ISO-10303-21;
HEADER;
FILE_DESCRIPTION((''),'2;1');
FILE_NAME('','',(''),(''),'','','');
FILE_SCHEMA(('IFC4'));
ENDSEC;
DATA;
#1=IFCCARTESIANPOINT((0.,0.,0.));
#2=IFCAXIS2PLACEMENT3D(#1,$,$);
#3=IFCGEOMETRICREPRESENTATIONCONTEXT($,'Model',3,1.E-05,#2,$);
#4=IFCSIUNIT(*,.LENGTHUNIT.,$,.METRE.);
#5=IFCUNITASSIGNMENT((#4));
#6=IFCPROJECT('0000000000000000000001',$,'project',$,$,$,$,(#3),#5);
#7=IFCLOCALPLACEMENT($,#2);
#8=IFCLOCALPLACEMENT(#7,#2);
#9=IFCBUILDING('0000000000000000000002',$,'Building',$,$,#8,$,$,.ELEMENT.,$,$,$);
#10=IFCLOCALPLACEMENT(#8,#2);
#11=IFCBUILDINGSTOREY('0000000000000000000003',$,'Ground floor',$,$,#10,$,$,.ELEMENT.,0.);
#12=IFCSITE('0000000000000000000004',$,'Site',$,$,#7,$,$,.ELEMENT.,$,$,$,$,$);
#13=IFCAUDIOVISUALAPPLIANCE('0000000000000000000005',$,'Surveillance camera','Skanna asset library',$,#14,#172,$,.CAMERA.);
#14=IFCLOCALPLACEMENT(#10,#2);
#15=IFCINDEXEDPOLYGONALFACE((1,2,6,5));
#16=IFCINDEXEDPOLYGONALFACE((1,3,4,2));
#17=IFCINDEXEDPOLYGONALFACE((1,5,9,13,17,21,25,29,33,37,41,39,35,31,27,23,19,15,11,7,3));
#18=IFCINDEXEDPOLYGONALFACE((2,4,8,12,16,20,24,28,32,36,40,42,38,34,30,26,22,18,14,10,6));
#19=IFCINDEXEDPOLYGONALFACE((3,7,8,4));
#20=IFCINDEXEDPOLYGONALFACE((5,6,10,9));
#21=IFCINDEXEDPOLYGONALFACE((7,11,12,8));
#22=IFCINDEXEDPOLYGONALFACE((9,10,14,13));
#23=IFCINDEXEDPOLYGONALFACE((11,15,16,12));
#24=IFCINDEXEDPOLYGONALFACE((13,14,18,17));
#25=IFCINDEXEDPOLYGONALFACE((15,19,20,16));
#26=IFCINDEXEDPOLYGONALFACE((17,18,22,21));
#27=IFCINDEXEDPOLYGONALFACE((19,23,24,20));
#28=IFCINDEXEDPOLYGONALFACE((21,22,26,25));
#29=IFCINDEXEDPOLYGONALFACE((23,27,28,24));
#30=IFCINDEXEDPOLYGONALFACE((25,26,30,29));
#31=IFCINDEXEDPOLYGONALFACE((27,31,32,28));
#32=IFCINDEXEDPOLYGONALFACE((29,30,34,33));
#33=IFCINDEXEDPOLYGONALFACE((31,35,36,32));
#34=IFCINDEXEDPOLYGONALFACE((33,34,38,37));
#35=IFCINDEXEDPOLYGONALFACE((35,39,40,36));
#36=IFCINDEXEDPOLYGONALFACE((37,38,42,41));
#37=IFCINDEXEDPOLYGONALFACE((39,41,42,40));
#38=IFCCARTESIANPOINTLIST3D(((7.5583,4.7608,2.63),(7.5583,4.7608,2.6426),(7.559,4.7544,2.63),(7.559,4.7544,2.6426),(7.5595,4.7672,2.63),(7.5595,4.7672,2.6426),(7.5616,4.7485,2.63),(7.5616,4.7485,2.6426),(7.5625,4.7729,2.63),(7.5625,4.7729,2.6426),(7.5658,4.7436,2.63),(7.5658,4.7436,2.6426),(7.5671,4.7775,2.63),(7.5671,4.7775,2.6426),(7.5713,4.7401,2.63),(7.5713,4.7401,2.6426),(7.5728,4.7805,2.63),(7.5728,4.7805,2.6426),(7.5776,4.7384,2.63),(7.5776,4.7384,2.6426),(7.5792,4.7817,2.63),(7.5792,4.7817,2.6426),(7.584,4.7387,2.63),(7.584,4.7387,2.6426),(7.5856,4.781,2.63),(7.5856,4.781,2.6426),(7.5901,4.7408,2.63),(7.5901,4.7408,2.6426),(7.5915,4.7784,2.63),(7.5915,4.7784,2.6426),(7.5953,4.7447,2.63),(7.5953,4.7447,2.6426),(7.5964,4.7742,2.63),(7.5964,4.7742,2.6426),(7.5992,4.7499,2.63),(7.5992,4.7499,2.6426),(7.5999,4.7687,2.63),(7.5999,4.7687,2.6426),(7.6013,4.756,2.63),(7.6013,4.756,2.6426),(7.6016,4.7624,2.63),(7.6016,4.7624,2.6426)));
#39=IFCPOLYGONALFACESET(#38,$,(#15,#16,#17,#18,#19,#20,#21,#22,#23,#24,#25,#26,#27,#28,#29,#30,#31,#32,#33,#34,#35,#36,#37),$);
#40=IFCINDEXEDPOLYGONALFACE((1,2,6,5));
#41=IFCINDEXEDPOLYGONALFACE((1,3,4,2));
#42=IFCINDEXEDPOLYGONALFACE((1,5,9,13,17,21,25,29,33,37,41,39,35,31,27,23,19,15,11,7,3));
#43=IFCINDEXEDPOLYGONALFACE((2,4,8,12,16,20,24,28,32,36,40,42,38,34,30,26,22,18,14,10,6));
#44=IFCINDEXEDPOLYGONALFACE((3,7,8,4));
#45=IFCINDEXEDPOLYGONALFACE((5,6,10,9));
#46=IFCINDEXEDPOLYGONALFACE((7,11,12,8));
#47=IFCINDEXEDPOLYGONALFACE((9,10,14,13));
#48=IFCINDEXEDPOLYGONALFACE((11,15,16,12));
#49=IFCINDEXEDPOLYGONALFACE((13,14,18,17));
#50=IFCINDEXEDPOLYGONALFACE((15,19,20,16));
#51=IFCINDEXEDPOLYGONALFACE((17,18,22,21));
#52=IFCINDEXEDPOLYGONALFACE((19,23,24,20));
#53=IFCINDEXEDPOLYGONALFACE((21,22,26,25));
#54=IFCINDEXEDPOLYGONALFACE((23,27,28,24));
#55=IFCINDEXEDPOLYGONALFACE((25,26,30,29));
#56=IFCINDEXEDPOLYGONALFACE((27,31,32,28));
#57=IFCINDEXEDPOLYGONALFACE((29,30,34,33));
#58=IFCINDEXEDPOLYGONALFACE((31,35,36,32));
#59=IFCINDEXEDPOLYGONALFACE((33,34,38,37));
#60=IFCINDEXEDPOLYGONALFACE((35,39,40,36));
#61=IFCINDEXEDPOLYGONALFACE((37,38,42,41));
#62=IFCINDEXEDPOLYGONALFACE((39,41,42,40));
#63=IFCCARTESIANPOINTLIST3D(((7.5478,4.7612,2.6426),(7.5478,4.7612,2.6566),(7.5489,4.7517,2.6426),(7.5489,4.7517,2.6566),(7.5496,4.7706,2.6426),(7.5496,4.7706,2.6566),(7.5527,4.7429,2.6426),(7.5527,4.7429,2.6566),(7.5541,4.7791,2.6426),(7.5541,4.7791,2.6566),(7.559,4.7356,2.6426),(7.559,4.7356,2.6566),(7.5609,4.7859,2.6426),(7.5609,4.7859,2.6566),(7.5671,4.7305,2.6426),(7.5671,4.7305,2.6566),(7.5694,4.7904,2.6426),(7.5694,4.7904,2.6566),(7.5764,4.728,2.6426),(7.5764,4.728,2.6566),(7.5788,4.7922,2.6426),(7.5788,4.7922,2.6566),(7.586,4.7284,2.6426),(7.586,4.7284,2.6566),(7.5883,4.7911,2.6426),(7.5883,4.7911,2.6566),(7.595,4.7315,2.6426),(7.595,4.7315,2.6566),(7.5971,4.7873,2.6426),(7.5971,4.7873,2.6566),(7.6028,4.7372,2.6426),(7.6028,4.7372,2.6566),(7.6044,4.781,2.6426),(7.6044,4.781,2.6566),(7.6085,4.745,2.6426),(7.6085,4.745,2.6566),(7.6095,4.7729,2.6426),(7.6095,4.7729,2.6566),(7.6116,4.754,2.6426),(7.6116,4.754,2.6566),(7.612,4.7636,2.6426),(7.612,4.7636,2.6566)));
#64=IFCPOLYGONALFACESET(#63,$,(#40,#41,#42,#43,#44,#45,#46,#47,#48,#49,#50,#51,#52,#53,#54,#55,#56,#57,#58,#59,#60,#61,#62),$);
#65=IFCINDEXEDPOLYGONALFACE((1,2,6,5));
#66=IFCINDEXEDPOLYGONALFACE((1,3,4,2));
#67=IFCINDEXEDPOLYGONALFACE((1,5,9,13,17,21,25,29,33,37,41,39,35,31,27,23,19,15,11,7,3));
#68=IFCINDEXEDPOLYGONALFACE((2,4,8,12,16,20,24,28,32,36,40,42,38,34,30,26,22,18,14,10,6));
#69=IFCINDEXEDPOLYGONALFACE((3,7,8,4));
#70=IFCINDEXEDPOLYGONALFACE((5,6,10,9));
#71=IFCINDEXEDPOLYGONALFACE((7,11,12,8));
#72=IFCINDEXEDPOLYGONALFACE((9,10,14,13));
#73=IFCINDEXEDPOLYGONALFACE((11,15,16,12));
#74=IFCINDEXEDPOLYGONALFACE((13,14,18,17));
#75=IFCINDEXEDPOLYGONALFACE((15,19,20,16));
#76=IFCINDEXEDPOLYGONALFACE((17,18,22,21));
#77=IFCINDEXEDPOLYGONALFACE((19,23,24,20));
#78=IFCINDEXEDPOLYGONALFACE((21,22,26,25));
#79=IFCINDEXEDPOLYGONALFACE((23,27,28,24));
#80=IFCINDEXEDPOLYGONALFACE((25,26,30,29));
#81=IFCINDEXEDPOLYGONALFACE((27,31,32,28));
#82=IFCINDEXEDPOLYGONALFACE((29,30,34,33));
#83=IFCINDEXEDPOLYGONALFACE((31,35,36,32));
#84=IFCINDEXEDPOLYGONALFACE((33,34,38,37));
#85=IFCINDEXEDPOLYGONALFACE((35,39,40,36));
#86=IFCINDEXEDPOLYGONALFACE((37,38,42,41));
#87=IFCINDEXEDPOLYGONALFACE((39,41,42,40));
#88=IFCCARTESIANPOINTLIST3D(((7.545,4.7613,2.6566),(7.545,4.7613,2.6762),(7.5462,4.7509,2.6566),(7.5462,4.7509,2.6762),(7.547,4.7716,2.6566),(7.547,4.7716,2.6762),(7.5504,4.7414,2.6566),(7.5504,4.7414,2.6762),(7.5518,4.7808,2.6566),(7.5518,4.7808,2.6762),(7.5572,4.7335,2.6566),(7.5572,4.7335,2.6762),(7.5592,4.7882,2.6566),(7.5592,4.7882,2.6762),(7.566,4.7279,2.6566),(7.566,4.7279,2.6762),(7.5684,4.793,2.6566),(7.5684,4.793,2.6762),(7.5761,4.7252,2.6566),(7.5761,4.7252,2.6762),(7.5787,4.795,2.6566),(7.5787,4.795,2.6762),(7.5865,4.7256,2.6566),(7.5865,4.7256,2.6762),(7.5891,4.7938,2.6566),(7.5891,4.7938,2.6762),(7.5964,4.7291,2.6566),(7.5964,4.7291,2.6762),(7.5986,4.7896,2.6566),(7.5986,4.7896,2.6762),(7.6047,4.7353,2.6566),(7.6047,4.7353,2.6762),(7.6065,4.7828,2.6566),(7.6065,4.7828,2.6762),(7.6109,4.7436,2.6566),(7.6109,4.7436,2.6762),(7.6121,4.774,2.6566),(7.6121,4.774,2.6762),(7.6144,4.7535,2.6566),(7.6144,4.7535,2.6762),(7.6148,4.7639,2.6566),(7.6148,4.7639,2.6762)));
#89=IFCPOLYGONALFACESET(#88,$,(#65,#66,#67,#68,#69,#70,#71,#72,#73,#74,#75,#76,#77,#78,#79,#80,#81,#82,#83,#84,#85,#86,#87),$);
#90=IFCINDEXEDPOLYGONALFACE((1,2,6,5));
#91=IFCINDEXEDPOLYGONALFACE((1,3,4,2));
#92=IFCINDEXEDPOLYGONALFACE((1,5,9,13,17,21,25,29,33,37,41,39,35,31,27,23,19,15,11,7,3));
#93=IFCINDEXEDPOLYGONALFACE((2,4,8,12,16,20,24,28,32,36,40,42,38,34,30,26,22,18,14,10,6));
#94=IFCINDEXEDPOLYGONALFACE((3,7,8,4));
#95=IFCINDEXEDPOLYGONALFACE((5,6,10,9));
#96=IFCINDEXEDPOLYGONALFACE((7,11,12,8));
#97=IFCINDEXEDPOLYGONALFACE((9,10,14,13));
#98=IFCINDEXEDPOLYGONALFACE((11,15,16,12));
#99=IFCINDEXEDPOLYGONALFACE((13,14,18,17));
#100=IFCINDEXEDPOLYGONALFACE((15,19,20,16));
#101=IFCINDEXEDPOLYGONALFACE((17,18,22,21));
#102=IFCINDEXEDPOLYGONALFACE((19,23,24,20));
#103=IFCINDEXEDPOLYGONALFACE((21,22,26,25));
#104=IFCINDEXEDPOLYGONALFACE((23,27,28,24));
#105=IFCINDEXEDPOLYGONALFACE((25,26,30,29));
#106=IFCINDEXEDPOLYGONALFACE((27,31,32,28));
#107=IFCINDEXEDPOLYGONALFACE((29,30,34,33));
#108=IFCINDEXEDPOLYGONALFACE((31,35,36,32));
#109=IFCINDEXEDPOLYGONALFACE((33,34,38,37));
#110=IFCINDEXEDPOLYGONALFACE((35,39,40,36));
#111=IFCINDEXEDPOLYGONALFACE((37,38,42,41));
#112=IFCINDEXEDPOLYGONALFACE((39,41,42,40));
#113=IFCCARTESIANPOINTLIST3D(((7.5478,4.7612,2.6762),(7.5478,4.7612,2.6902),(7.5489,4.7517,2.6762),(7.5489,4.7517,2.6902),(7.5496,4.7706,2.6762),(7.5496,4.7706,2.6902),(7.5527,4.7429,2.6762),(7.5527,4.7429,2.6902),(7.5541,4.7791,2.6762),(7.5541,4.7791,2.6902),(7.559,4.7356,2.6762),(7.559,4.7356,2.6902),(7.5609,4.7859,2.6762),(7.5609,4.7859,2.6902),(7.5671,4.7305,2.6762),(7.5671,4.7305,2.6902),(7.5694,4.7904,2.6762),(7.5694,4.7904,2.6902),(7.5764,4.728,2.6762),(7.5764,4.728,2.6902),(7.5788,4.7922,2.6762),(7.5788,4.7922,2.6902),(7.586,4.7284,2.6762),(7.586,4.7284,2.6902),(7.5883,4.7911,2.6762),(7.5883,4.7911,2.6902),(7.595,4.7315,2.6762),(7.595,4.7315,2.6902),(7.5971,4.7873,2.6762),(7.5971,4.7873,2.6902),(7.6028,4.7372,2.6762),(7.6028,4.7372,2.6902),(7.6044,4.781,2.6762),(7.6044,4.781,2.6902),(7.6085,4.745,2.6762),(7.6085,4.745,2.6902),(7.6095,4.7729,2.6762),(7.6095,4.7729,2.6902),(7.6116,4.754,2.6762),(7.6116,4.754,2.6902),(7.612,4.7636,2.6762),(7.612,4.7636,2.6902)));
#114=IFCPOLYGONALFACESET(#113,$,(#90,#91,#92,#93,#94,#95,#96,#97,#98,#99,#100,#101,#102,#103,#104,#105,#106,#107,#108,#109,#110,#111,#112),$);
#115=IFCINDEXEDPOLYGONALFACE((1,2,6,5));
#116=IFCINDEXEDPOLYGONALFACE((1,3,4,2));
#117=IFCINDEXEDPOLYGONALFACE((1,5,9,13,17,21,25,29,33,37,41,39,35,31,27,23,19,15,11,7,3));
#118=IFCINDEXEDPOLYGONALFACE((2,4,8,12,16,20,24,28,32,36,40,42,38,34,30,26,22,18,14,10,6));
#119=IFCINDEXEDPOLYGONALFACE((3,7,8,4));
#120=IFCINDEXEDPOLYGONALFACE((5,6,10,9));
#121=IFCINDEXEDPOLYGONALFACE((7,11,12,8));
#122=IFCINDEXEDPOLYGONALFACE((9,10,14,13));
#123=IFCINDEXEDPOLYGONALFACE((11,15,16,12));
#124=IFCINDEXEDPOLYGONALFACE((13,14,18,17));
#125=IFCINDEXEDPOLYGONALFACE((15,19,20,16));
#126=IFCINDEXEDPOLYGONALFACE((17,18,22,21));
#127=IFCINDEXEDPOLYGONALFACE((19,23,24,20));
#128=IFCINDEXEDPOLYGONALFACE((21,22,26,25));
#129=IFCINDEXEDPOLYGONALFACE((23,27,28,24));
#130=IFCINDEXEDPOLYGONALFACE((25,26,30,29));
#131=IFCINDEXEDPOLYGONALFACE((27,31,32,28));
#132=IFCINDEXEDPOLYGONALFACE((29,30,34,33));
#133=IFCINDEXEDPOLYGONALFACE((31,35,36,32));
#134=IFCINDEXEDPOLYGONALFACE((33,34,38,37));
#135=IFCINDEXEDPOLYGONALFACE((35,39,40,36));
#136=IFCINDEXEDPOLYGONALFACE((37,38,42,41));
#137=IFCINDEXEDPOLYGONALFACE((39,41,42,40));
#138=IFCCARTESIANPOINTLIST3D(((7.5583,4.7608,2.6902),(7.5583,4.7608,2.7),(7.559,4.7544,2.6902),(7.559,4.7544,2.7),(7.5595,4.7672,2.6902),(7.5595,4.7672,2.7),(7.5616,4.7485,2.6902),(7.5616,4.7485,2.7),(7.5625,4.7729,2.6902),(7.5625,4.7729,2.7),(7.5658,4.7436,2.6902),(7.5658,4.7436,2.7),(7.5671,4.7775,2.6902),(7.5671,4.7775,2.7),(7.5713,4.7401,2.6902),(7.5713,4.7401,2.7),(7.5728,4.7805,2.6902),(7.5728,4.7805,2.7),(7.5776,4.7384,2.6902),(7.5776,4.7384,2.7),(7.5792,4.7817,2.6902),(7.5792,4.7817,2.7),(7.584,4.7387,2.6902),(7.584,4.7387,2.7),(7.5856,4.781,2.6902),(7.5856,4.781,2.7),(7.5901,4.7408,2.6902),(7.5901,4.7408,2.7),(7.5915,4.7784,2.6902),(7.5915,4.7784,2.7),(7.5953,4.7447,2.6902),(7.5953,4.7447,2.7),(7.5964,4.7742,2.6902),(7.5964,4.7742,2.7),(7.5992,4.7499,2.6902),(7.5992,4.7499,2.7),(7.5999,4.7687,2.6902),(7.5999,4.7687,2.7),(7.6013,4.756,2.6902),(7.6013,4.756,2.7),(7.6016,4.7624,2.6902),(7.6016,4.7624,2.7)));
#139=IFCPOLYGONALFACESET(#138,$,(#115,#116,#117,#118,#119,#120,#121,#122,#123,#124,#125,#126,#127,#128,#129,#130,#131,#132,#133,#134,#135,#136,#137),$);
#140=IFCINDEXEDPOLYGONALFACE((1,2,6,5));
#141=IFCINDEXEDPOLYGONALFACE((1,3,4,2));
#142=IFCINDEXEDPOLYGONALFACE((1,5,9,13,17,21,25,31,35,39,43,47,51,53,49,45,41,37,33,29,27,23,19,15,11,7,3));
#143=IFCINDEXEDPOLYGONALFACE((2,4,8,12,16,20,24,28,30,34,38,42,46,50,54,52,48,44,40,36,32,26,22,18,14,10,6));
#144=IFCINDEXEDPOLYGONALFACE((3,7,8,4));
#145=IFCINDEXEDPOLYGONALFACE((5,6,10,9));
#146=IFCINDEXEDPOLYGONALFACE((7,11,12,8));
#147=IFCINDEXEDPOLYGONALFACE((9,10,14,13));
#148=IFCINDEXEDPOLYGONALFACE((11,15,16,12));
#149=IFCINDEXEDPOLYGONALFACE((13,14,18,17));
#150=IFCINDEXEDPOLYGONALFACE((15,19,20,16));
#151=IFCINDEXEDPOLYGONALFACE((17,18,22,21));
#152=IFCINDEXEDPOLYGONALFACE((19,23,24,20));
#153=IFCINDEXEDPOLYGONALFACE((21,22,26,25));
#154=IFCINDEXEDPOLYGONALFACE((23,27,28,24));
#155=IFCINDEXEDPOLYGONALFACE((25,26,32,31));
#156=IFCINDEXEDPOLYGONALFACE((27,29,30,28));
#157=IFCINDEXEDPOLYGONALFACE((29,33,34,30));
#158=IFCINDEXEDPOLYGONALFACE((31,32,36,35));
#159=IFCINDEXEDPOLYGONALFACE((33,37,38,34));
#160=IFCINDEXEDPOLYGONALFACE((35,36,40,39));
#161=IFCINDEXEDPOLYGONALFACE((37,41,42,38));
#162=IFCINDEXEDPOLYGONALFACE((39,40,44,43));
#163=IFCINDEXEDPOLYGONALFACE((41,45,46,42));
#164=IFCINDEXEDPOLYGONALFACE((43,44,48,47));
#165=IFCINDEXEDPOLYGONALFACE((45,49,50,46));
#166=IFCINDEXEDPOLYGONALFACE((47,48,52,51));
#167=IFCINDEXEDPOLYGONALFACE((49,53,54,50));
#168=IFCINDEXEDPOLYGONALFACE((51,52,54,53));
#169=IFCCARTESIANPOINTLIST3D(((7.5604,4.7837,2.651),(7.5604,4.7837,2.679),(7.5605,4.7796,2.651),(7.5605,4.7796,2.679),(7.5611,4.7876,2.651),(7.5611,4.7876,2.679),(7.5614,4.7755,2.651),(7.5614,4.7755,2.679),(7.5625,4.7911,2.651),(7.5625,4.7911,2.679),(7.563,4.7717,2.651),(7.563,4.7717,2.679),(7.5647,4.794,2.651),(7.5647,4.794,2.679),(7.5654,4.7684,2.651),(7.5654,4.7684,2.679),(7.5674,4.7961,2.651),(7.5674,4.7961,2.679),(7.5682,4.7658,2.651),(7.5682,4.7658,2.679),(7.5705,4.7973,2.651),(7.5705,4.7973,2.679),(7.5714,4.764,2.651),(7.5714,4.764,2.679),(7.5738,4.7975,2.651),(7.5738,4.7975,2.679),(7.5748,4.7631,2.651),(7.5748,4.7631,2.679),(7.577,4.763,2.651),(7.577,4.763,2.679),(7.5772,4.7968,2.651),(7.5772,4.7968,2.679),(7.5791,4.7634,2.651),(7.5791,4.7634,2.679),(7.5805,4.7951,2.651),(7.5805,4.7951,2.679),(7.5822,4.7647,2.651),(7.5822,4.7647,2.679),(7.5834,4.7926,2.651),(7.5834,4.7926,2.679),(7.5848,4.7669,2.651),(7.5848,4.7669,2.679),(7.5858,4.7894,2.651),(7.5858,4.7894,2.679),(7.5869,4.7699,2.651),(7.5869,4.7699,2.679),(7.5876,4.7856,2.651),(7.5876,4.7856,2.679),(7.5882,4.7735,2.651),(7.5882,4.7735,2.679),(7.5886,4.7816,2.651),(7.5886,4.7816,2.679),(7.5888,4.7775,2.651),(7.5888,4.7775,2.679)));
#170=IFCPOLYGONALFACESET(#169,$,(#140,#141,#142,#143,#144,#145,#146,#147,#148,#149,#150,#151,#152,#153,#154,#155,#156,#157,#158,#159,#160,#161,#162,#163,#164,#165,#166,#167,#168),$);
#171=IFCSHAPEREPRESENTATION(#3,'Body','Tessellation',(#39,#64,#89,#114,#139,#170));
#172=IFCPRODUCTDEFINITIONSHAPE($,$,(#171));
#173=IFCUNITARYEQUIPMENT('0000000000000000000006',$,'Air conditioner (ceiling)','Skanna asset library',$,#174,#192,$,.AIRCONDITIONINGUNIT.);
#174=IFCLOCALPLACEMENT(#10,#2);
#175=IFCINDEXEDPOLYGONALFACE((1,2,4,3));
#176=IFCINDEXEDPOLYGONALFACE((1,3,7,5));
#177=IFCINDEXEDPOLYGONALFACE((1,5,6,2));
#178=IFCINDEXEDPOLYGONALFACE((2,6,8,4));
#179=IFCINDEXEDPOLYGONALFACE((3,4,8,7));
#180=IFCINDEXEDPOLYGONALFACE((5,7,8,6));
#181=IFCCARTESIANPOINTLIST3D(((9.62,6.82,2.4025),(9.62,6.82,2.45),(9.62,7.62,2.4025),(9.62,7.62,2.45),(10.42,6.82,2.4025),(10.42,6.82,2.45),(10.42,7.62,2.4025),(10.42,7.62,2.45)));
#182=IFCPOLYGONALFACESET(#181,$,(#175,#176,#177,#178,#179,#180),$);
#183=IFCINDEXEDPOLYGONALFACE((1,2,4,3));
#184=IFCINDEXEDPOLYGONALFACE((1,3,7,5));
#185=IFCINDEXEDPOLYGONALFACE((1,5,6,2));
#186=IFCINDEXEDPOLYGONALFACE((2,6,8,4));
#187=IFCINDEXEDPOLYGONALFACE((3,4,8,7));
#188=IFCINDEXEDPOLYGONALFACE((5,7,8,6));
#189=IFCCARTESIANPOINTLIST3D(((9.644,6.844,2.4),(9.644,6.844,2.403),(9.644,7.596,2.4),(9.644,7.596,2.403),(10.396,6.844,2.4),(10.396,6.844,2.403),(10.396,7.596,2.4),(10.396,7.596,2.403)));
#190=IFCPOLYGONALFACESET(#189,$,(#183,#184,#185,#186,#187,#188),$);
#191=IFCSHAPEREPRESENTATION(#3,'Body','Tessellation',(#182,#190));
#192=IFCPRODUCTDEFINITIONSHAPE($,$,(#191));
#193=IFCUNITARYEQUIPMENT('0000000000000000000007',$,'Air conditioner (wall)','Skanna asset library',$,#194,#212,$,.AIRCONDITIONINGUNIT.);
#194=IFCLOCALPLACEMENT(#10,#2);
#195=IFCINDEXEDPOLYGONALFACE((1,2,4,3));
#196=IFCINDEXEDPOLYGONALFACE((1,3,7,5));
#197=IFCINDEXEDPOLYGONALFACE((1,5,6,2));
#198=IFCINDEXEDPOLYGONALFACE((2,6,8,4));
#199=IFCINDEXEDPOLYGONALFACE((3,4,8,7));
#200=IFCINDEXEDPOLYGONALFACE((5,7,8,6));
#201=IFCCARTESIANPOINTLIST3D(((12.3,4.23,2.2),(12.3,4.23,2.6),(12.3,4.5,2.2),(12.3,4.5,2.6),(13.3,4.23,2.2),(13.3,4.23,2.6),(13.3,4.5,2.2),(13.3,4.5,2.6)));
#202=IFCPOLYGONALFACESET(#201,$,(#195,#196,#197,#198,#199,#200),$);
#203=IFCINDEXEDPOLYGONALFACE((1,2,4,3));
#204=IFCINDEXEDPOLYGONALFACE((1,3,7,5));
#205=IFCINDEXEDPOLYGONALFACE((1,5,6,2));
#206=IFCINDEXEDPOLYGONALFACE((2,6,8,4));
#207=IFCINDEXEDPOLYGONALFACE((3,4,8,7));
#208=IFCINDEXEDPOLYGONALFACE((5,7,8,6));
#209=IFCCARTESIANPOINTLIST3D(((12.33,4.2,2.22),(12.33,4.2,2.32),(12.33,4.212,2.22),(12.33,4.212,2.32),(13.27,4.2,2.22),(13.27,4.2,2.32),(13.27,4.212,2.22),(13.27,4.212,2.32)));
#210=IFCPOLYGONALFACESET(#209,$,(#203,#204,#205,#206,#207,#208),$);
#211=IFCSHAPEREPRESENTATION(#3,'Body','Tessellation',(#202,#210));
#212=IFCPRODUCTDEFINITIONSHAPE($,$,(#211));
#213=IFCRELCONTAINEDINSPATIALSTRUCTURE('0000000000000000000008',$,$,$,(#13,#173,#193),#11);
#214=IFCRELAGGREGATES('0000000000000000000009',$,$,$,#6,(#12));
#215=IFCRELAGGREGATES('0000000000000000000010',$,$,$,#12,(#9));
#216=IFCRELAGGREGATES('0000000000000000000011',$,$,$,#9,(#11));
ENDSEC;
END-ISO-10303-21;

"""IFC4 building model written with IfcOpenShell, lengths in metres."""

from ifc_helpers import new_model, si_unit, frame, frame_2d, origin, origin_2d, place, context, project, spatial, rectangle, circle, ellipse, extrude, element, save


model = new_model("IFC4")

# Units and contexts
model_context = context("Model", 3, precision=1e-05, world=origin())
ifc_project = project(units=[si_unit("LENGTHUNIT", "METRE")], contexts=[model_context])

# Site, building, storey
site_placement = place(None, origin())
site = spatial("IfcSite", under=ifc_project, at=site_placement, Name="Site", CompositionType="ELEMENT")
building_placement = place(site_placement, origin())
building = spatial("IfcBuilding", under=site, at=building_placement, Name="Building", CompositionType="ELEMENT")
storey_placement = place(building_placement, origin())
storey = spatial("IfcBuildingStorey", under=building, at=storey_placement, Name="Ground floor", CompositionType="ELEMENT", Elevation=0.0)

# Audio visual appliance
audio_visual_appliance_placement = place(storey_placement, frame((7.58, 4.76, 2.63), z_axis=(0.0, 0.0, 1.0), x_axis=(-0.965926, -0.258819, 0.0)))
element("IfcAudioVisualAppliance", 1, at=audio_visual_appliance_placement, inside=storey, Name="Surveillance camera", Description="Skanna asset library", PredefinedType="CAMERA", context=model_context, shape_type="SweptSolid", body=[
    extrude(circle(Radius=0.0217, at=origin_2d()), origin(), (0.0, 0.0, 1.0), 0.0126),
    extrude(circle(Radius=0.0322, at=origin_2d()), frame((0.0, 0.0, 0.0126)), (0.0, 0.0, 1.0), 0.014),
    extrude(circle(Radius=0.035, at=origin_2d()), frame((0.0, 0.0, 0.0266)), (0.0, 0.0, 1.0), 0.0196),
    extrude(circle(Radius=0.0322, at=origin_2d()), frame((0.0, 0.0, 0.0462)), (0.0, 0.0, 1.0), 0.014),
    extrude(circle(Radius=0.0217, at=origin_2d()), frame((0.0, 0.0, 0.0602)), (0.0, 0.0, 1.0), 0.0098),
    extrude(ellipse(SemiAxis1=0.014, SemiAxis2=0.0175, at=frame_2d((0.0, -0.021))), frame((0.0, 0.0, 0.021)), (0.0, 0.0, 1.0), 0.028),
])

# Unitary equipment
unitary_equipment_1_placement = place(storey_placement, frame((10.02, 7.22, 2.4), z_axis=(0.0, 0.0, 1.0), x_axis=(1.0, 0.0, 0.0)))
element("IfcUnitaryEquipment", 2, at=unitary_equipment_1_placement, inside=storey, Name="Air conditioner (ceiling)", Description="Skanna asset library", PredefinedType="AIRCONDITIONINGUNIT", context=model_context, shape_type="SweptSolid", body=[
    extrude(rectangle(XDim=0.8, YDim=0.8, at=origin_2d()), frame((0.0, 0.0, 0.0025)), (0.0, 0.0, 1.0), 0.0475),
    extrude(rectangle(XDim=0.752, YDim=0.752, at=origin_2d()), origin(), (0.0, 0.0, 1.0), 0.003),
])
unitary_equipment_2_placement = place(storey_placement, frame((12.8, 4.35, 2.2), z_axis=(0.0, 0.0, 1.0), x_axis=(1.0, 0.0, 0.0)))
element("IfcUnitaryEquipment", 3, at=unitary_equipment_2_placement, inside=storey, Name="Air conditioner (wall)", Description="Skanna asset library", PredefinedType="AIRCONDITIONINGUNIT", context=model_context, shape_type="SweptSolid", body=[
    extrude(rectangle(XDim=1.0, YDim=0.27, at=frame_2d((0.0, 0.015))), origin(), (0.0, 0.0, 1.0), 0.4),
    extrude(rectangle(XDim=0.94, YDim=0.012, at=frame_2d((0.0, -0.144))), frame((0.0, 0.0, 0.02)), (0.0, 0.0, 1.0), 0.1),
])

save(model, "model.ifc")
